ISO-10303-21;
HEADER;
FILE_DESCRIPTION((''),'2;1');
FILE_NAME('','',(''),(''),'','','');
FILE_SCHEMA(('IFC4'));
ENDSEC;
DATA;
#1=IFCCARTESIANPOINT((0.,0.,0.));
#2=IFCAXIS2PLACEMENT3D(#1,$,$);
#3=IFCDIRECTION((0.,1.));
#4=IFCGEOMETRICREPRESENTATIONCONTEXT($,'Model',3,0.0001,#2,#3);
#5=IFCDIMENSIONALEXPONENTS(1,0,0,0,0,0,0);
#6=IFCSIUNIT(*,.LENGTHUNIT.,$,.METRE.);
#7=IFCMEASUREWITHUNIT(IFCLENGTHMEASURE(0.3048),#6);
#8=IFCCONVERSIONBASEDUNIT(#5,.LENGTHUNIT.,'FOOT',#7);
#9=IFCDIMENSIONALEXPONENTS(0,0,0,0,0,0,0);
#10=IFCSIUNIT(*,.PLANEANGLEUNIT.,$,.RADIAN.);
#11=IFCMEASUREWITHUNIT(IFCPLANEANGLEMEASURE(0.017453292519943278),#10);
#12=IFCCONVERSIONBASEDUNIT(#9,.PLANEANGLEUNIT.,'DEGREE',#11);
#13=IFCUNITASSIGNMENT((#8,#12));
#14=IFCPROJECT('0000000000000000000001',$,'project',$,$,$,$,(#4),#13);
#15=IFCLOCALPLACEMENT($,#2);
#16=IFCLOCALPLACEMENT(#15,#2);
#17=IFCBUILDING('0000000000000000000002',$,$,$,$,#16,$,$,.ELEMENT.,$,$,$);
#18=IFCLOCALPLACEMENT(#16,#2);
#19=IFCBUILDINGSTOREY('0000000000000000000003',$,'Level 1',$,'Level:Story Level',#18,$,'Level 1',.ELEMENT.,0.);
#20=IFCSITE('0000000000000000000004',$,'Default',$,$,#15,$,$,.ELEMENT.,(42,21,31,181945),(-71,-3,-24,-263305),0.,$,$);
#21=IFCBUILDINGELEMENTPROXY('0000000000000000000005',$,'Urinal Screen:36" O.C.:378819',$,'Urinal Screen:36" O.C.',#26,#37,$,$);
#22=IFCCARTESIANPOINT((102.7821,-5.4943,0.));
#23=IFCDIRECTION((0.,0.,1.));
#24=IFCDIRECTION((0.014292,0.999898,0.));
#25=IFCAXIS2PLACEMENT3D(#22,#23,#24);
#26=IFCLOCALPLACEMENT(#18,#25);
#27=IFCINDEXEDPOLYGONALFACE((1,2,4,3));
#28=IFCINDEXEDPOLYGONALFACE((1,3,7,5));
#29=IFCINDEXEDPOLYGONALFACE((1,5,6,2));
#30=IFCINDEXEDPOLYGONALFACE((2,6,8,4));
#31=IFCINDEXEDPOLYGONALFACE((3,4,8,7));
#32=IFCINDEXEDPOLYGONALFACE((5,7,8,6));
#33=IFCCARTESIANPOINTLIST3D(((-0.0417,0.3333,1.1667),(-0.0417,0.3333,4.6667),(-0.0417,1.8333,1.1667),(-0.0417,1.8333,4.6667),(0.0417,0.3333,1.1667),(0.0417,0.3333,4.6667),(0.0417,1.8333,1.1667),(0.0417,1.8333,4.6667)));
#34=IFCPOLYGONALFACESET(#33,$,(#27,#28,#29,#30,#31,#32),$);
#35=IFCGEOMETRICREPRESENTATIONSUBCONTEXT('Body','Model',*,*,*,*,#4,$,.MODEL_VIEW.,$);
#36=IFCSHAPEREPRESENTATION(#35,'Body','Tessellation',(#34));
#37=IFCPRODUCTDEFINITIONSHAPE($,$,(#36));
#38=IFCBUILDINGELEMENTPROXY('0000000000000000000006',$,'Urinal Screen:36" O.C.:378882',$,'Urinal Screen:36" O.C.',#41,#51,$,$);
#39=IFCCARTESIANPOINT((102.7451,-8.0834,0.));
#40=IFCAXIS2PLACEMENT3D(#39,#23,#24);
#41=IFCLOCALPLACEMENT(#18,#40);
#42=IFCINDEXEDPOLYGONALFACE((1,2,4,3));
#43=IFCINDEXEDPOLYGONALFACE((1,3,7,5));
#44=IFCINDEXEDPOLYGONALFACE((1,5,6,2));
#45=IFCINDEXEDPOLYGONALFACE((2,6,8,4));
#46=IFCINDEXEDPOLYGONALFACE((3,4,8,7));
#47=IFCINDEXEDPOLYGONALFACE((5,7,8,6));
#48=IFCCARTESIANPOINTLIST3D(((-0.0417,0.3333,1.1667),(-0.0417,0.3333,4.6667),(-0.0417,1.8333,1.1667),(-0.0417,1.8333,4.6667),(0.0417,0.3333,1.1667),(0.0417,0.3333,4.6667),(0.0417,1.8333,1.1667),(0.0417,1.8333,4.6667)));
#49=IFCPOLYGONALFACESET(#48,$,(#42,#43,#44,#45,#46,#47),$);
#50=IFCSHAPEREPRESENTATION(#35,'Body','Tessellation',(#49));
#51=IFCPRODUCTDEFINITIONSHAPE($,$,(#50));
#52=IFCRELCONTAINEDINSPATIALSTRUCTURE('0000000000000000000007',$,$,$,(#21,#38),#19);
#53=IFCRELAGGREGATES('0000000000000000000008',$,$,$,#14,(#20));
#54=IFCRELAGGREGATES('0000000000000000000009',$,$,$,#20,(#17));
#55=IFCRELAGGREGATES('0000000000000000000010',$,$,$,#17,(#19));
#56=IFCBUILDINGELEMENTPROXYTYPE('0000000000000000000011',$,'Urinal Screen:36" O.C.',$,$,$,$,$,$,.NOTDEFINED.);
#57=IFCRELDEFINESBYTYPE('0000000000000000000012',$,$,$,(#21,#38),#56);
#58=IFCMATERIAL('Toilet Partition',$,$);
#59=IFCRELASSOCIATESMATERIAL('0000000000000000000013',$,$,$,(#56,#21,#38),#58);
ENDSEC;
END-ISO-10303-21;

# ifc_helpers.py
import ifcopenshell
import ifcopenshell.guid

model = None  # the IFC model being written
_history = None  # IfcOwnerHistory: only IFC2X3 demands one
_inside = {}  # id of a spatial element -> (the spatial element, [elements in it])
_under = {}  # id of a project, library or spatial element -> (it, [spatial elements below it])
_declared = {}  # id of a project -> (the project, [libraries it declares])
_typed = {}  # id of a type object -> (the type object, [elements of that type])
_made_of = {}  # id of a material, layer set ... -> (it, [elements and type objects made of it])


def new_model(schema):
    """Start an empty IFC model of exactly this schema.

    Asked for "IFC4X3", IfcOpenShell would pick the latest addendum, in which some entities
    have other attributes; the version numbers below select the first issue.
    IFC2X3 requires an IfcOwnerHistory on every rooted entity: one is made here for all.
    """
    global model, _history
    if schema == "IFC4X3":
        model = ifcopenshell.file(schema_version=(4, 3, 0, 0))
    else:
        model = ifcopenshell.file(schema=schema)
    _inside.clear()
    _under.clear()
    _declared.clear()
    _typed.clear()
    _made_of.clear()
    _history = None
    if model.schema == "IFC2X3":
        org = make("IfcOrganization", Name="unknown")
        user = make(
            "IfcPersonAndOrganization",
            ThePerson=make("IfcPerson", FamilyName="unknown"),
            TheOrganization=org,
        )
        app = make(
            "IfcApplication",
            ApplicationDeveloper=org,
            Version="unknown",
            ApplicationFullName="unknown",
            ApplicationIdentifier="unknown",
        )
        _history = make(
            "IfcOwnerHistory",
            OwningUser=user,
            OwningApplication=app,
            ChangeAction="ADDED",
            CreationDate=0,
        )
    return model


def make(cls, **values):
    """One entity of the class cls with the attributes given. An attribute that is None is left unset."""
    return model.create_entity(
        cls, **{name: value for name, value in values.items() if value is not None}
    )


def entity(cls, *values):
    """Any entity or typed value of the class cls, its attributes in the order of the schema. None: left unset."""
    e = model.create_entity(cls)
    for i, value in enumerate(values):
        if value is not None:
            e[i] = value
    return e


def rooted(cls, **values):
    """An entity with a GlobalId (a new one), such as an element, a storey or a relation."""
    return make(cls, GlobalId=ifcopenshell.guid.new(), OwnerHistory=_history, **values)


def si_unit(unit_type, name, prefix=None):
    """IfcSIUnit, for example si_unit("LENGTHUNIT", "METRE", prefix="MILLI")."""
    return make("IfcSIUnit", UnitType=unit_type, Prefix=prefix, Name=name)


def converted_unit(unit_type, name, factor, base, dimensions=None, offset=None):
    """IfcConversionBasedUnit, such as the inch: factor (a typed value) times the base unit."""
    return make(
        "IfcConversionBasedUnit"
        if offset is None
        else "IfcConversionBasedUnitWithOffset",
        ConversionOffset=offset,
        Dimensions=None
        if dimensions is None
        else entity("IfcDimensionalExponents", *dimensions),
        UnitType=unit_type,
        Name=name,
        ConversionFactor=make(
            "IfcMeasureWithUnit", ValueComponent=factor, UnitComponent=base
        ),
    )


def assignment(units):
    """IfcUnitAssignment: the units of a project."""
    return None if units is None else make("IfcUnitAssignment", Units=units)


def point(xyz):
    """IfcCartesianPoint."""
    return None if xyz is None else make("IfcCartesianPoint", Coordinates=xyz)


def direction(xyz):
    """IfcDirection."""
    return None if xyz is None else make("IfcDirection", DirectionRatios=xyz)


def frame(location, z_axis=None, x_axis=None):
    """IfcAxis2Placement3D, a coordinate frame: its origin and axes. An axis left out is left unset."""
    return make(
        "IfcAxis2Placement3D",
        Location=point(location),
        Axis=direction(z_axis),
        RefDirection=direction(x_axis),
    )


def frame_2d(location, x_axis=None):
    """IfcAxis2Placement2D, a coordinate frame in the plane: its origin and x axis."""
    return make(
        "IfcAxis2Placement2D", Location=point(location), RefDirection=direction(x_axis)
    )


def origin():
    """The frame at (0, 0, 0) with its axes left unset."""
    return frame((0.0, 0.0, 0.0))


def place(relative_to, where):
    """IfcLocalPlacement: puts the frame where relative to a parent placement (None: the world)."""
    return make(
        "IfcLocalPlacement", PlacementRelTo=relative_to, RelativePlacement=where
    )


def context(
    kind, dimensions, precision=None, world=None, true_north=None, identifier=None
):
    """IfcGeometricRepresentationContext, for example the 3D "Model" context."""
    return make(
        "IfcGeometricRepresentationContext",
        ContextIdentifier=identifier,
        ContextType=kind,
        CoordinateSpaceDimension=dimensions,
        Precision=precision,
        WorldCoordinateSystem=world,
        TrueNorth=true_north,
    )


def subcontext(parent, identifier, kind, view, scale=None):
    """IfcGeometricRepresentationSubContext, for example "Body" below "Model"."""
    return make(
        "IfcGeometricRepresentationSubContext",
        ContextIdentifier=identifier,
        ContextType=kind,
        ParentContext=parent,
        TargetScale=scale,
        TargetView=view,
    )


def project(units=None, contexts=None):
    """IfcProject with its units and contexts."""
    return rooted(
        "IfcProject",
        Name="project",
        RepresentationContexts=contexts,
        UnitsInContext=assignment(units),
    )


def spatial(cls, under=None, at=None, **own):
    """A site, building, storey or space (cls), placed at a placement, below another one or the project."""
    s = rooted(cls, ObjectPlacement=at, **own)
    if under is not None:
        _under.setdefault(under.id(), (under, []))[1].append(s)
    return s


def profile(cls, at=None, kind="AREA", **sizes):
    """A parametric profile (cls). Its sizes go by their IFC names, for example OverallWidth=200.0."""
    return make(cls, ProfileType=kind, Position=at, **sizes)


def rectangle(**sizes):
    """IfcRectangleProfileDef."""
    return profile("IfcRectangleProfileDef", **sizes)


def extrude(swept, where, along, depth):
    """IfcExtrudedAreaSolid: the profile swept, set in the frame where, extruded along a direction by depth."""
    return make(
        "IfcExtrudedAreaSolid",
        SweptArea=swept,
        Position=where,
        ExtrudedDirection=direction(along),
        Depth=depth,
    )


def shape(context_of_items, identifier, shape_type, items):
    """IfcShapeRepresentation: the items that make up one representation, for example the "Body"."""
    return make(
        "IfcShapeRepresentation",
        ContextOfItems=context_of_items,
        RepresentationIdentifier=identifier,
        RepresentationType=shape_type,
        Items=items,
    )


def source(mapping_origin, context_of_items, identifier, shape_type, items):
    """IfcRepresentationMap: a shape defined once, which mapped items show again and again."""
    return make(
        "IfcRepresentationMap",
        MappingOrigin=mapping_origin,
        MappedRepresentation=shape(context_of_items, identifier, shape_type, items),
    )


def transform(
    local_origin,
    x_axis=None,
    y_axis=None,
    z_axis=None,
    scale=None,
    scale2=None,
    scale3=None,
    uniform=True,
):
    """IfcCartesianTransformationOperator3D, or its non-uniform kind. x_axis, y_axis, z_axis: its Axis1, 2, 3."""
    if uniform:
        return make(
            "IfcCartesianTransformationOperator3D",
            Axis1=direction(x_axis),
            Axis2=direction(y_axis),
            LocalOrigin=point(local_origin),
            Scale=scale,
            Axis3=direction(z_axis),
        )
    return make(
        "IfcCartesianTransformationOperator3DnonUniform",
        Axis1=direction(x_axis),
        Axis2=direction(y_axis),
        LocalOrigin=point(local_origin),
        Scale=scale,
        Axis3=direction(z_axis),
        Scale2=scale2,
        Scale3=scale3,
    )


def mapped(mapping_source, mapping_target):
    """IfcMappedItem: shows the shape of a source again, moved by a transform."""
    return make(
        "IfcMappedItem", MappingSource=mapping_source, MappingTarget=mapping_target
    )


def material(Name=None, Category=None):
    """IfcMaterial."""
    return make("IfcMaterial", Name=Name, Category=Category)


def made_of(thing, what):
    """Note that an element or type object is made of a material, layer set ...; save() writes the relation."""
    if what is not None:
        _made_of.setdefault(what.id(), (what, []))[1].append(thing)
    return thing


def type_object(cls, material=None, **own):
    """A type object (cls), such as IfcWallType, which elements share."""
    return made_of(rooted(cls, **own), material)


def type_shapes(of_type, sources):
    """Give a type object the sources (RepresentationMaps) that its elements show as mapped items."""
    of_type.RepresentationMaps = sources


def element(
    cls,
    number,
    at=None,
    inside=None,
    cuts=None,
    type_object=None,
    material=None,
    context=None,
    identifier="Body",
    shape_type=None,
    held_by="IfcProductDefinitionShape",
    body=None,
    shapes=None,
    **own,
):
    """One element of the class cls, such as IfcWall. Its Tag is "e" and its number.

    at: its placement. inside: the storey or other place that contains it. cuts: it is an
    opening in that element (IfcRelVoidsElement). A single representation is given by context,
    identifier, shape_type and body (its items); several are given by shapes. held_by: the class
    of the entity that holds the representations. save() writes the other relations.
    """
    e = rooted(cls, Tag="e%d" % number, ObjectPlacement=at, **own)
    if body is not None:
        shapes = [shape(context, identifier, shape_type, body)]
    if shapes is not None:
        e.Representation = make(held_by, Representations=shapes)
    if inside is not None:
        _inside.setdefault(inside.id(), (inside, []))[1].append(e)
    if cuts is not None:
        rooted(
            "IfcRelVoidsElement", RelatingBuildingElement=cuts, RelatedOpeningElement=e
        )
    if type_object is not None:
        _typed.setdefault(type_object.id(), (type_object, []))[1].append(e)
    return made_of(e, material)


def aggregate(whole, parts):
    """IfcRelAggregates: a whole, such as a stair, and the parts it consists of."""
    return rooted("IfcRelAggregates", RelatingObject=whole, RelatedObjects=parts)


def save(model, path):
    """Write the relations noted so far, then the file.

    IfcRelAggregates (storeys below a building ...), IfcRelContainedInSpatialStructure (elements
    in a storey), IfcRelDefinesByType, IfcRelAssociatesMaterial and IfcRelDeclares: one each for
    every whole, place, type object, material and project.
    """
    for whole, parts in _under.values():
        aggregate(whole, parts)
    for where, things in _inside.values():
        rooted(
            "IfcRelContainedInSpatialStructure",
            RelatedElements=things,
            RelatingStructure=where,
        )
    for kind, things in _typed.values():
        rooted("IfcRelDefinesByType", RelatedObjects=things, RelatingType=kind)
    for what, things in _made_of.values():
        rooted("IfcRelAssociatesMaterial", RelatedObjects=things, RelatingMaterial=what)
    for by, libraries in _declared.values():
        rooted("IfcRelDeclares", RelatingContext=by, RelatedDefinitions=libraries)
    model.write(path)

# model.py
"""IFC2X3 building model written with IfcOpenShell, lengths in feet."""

from ifc_helpers import new_model, entity, si_unit, converted_unit, direction, frame, frame_2d, origin, place, context, subcontext, project, spatial, rectangle, extrude, source, transform, mapped, material, type_object, type_shapes, element, save


model = new_model("IFC2X3")

# Units and contexts
model_context = context("Model", 3, precision=0.0001, world=origin(), true_north=direction((0.0, 1.0)))
body_context = subcontext(model_context, "Body", "Model", "MODEL_VIEW")
ifc_project = project(units=[converted_unit("LENGTHUNIT", "FOOT", entity("IfcLengthMeasure", 0.3048), si_unit("LENGTHUNIT", "METRE"), dimensions=[1, 0, 0, 0, 0, 0, 0]), converted_unit("PLANEANGLEUNIT", "DEGREE", entity("IfcPlaneAngleMeasure", 0.017453292519943278), si_unit("PLANEANGLEUNIT", "RADIAN"), dimensions=[0, 0, 0, 0, 0, 0, 0])], contexts=[model_context])

# Site, building, storey
site_placement = place(None, origin())
site = spatial("IfcSite", under=ifc_project, at=site_placement, Name="Default", CompositionType="ELEMENT", RefLatitude=(42, 21, 31, 181945), RefLongitude=(-71, -3, -24, -263305), RefElevation=0.0)
building_placement = place(site_placement, origin())
building = spatial("IfcBuilding", under=site, at=building_placement, CompositionType="ELEMENT")
storey_placement = place(building_placement, origin())
storey = spatial("IfcBuildingStorey", under=building, at=storey_placement, Name="Level 1", ObjectType="Level:Story Level", LongName="Level 1", CompositionType="ELEMENT", Elevation=0.0)

# Building element proxies
ifc_material_1 = material(Name="Toilet Partition")
building_element_proxy_type = type_object("IfcBuildingElementProxyType", Name="Urinal Screen:36\" O.C.", PredefinedType="NOTDEFINED", material=ifc_material_1)
shared_shape_1 = source(origin(), body_context, "Body", "SweptSolid", [
    extrude(rectangle(XDim=1.5, YDim=0.0833, at=frame_2d((0.0, 0.0), x_axis=(1.0, 0.0))), frame((0.0, 1.0833, 1.1667), z_axis=(0.0, 0.0, 1.0), x_axis=(0.0, 1.0, 0.0)), (0.0, 0.0, 1.0), 3.5),
])
type_shapes(building_element_proxy_type, [shared_shape_1])
for number, where, z_axis, x_axis, name in (
    (1, (102.7821, -5.4943, 0.0), (0.0, 0.0, 1.0), (0.014292, 0.999898, 0.0), "Urinal Screen:36\" O.C.:378819"),
    (2, (102.7451, -8.0834, 0.0), (0.0, 0.0, 1.0), (0.014292, 0.999898, 0.0), "Urinal Screen:36\" O.C.:378882"),
):
    element("IfcBuildingElementProxy", number, at=place(storey_placement, frame(where, z_axis=z_axis, x_axis=x_axis)), inside=storey, type_object=building_element_proxy_type, material=ifc_material_1, Name=name, ObjectType="Urinal Screen:36\" O.C.", context=body_context, shape_type="MappedRepresentation", body=[
        mapped(shared_shape_1, transform((0.0, 0.0, 0.0), scale=1.0)),
    ])

save(model, "model.ifc")
